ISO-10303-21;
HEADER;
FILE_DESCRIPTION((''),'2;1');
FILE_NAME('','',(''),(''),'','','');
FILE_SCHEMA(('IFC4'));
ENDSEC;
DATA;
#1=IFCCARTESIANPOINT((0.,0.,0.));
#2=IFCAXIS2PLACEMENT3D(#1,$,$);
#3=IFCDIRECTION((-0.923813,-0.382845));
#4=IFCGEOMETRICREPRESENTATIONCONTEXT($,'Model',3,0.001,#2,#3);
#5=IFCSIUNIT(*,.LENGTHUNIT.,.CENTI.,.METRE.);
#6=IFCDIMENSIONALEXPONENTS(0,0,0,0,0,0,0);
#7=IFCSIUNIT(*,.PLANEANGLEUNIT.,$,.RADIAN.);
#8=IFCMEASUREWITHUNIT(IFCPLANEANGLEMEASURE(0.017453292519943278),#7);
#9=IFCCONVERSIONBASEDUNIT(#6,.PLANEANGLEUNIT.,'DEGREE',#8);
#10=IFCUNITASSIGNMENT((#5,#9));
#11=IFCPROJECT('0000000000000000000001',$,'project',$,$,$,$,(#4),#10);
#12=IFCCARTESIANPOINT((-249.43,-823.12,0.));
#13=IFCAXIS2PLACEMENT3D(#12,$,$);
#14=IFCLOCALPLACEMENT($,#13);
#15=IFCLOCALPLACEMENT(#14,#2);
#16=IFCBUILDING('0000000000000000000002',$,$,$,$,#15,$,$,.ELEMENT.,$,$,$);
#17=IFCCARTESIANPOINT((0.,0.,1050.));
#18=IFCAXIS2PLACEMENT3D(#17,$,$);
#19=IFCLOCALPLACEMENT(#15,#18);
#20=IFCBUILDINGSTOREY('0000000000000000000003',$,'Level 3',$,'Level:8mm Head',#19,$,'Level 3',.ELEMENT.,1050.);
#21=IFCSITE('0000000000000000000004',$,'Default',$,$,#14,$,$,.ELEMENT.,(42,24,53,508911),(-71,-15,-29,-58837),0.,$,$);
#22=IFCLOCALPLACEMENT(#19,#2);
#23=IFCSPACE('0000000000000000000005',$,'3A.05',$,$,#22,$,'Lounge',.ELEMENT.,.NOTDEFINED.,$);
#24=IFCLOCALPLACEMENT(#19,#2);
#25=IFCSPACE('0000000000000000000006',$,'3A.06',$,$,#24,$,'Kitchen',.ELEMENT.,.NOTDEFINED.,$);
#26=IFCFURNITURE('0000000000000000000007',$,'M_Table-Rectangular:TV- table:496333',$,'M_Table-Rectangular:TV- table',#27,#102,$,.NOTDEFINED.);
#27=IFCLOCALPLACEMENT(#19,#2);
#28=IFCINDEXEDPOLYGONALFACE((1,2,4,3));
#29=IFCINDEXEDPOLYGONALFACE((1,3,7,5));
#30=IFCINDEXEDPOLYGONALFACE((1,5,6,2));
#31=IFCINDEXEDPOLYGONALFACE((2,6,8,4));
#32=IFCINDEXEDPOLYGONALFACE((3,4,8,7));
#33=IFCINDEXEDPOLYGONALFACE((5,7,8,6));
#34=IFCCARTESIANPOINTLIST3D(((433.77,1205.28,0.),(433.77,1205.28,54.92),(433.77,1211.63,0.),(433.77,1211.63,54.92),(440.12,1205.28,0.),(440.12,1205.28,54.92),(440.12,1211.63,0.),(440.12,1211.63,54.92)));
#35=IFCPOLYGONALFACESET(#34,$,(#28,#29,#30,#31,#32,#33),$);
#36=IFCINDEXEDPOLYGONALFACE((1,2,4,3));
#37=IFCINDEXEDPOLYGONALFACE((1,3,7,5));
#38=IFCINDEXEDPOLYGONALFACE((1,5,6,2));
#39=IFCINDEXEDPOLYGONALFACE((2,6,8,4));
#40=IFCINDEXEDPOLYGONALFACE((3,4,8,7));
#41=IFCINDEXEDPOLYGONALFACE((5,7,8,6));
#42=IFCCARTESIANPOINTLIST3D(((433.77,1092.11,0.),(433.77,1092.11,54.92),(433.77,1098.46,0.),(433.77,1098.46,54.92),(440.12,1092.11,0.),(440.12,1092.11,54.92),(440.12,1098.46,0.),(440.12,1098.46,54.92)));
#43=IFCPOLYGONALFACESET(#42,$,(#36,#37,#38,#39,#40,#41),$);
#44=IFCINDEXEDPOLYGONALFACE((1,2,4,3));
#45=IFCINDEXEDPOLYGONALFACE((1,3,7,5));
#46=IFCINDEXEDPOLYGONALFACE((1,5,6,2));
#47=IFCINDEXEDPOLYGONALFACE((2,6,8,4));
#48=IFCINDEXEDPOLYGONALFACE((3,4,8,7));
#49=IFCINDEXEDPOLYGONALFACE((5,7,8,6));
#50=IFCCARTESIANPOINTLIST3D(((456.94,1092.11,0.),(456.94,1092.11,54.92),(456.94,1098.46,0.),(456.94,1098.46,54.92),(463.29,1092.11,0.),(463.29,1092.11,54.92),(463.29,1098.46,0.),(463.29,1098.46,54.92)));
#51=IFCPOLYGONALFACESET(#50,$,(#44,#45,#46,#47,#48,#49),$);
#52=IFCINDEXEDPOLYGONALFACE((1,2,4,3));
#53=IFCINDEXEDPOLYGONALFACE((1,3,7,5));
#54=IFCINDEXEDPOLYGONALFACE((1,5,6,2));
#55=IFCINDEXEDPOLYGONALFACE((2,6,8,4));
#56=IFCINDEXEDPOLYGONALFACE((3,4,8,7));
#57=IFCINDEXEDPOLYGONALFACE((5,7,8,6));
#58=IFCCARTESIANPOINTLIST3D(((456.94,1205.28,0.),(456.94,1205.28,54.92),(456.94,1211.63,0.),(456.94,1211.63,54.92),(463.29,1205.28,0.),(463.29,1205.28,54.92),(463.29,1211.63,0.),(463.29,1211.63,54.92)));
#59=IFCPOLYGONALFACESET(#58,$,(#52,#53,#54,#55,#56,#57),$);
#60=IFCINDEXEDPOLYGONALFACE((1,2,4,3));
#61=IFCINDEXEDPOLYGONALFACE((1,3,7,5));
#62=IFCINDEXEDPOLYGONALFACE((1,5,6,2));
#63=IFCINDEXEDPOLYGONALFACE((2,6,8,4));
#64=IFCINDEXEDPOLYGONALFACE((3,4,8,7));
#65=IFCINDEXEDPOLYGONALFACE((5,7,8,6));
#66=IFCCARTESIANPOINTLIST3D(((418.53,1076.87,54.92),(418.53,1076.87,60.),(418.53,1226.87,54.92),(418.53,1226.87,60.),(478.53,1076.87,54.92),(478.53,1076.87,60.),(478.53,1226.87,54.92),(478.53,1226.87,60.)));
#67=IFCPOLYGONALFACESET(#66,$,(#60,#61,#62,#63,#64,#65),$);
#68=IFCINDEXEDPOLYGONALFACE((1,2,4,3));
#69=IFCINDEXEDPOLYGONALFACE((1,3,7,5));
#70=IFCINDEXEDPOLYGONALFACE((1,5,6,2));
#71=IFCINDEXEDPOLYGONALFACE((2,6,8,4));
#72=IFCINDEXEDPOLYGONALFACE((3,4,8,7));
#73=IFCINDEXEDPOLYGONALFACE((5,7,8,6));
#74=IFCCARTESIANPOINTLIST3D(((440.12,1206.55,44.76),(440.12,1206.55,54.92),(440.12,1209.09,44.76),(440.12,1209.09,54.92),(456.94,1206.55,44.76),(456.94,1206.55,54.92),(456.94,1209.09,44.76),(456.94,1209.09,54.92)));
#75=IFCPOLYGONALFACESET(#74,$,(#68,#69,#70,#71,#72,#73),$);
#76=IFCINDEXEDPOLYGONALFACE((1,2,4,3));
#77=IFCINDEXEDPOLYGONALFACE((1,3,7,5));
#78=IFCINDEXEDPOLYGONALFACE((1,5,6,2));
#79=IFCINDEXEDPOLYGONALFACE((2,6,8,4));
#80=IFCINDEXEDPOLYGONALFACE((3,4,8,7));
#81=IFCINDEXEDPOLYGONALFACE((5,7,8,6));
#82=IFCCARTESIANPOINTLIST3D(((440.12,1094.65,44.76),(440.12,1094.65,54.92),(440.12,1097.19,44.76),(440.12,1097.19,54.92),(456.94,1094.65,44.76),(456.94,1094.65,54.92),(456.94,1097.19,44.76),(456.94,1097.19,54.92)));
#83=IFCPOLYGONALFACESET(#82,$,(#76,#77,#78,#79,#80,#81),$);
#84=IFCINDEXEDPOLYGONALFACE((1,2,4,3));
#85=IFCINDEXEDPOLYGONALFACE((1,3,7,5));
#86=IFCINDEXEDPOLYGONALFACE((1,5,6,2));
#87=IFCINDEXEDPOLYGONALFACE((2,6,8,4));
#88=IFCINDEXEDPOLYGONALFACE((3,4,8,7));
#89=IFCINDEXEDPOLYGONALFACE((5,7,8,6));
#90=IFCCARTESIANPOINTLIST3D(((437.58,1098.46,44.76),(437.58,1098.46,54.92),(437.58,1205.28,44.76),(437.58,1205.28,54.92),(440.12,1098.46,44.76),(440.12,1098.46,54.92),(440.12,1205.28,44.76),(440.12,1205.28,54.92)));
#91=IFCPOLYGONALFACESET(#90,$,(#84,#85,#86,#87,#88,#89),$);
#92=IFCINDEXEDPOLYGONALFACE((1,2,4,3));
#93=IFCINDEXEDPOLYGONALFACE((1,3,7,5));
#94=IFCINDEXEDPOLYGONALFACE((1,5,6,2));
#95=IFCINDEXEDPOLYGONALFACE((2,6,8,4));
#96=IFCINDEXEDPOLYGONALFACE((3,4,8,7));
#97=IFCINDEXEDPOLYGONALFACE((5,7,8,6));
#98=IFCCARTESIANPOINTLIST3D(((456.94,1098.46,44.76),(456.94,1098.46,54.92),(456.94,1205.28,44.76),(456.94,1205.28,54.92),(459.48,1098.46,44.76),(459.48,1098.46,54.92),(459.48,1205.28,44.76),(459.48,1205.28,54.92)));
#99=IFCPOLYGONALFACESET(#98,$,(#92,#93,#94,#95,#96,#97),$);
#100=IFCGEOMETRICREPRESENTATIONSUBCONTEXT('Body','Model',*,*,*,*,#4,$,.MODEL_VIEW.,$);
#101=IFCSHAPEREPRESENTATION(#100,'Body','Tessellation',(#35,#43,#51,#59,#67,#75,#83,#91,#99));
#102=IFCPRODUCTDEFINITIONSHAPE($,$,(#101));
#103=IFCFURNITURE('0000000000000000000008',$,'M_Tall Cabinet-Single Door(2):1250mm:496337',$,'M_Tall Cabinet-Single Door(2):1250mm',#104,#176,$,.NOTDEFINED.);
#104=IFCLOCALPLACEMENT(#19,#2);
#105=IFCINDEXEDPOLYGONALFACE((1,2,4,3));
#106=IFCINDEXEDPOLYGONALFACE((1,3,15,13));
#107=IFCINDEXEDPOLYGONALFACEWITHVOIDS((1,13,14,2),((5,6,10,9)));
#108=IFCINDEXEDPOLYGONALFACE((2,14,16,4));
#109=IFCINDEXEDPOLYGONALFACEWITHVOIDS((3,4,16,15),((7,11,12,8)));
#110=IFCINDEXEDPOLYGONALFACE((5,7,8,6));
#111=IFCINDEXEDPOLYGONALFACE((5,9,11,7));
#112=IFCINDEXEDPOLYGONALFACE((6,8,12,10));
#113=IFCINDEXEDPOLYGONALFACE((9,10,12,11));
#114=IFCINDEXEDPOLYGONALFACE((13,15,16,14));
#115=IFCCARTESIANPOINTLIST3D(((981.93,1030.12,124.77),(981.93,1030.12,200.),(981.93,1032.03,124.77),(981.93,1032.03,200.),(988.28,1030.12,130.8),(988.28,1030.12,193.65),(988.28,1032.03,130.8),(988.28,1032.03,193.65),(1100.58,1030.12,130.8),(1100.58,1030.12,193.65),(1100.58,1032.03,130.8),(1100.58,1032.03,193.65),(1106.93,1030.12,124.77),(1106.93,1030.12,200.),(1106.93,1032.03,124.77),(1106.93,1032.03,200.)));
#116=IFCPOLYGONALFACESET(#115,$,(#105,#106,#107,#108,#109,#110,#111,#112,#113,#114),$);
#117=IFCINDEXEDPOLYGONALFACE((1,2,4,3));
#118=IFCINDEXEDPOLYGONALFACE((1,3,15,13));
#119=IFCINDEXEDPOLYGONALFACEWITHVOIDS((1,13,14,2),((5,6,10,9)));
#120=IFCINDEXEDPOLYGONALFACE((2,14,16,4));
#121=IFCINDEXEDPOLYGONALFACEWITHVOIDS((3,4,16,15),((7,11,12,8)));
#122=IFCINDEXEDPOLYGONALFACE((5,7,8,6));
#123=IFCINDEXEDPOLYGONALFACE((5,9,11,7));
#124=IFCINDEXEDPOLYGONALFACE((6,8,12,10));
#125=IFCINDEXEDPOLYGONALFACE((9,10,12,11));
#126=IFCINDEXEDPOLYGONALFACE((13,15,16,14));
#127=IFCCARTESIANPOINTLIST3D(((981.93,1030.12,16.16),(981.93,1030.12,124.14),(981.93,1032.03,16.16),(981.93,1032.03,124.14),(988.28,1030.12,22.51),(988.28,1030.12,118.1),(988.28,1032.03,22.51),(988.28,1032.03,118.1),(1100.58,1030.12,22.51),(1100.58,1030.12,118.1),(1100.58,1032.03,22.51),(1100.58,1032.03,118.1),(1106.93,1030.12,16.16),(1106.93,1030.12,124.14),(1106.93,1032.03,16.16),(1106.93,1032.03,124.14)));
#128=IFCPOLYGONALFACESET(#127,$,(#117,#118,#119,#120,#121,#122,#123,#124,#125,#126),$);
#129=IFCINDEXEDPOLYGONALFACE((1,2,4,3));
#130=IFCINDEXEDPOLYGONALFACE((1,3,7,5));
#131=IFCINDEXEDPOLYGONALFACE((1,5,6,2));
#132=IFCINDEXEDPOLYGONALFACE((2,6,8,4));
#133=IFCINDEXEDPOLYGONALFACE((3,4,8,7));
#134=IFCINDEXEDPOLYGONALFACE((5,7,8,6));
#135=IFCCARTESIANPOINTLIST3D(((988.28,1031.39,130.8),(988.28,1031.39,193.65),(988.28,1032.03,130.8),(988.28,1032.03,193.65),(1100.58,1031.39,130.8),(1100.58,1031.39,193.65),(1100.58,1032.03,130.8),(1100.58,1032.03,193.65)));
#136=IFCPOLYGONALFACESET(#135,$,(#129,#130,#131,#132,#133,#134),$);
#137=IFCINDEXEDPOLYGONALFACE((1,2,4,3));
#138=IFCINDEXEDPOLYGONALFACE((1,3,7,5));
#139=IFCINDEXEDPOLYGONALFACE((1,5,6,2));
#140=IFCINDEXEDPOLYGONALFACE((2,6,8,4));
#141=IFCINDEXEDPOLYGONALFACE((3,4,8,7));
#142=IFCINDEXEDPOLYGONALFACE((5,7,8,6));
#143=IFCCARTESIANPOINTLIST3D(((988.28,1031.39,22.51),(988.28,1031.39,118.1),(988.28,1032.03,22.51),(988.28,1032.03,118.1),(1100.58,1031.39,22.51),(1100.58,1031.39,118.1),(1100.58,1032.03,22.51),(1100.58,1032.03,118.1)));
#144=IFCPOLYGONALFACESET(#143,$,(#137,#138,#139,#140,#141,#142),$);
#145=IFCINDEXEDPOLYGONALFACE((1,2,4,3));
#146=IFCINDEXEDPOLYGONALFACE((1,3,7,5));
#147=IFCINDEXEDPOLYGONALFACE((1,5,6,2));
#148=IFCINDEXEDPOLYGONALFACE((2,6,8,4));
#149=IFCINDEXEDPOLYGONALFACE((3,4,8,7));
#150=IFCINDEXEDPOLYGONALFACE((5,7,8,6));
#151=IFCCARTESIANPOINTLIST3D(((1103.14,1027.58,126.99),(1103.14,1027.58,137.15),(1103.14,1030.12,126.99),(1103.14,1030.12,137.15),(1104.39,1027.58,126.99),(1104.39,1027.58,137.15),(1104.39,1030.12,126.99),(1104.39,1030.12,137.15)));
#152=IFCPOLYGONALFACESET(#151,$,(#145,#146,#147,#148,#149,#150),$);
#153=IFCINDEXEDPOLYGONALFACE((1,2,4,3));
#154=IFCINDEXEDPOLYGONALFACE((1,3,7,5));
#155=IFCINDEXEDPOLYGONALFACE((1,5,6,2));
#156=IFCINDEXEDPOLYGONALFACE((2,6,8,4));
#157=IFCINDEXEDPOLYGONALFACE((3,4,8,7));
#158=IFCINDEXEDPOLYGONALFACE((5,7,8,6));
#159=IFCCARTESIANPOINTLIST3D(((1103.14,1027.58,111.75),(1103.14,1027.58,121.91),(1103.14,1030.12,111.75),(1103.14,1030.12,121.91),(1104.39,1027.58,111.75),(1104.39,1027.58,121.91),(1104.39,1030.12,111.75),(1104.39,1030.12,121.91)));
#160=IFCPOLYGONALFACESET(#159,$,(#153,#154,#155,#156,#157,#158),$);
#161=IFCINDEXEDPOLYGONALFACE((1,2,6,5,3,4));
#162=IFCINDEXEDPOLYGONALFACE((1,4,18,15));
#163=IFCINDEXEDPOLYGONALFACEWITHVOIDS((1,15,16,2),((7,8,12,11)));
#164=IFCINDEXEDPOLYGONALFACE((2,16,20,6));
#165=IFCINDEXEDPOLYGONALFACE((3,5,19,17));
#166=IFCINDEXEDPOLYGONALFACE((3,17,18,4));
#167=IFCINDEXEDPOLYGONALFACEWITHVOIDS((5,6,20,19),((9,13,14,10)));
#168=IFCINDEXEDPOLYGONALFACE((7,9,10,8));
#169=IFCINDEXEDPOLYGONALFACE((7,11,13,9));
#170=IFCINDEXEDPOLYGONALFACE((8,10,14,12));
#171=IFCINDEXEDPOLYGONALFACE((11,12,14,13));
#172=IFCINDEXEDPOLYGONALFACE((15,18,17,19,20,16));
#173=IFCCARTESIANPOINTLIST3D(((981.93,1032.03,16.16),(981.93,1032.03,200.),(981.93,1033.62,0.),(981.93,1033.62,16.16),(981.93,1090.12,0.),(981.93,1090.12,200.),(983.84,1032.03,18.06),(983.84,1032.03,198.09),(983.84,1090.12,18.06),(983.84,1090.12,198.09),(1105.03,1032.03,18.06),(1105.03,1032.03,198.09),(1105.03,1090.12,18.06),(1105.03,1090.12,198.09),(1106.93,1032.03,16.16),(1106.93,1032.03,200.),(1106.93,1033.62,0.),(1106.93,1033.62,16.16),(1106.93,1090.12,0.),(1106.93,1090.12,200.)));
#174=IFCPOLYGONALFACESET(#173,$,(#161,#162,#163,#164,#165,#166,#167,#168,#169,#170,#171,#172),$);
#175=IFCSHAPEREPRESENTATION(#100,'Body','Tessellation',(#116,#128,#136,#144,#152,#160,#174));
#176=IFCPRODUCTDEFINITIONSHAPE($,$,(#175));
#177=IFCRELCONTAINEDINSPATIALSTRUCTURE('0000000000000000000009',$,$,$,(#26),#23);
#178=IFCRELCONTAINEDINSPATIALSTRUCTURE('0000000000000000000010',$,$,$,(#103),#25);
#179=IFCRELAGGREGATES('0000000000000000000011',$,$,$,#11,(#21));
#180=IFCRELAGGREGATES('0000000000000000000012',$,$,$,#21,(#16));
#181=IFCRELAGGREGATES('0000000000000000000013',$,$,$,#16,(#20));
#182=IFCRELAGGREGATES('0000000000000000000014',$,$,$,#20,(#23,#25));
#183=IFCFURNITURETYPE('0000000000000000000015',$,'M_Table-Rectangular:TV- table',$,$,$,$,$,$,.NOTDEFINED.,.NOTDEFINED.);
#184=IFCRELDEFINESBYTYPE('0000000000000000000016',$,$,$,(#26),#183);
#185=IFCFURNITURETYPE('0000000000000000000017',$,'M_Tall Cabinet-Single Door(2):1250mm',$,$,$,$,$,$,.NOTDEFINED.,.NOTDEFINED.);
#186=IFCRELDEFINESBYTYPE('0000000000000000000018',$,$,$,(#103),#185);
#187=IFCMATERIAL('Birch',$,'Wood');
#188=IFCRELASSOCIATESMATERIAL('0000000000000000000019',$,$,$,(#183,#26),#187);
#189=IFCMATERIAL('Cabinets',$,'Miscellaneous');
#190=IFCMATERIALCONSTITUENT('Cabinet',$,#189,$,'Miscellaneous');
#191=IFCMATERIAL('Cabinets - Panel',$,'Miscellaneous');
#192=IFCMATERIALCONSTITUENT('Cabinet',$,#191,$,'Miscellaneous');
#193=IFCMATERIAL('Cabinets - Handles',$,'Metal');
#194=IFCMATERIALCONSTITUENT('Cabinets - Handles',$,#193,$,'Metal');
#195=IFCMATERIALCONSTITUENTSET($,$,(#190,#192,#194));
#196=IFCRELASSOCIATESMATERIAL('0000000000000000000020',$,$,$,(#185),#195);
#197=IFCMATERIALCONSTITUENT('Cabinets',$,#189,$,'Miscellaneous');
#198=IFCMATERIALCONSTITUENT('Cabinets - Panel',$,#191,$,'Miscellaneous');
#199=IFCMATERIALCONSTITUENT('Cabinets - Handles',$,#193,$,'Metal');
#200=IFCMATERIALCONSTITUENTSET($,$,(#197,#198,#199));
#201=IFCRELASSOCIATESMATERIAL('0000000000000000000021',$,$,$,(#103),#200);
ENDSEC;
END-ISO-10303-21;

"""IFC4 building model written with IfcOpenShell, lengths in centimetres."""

from ifc_helpers import new_model, entity, si_unit, converted_unit, direction, frame, origin, place, context, subcontext, project, spatial, indexed_curve, outline, extrude, source, transform, mapped, material, constituent, constituent_set, type_object, type_shapes, element, save


model = new_model("IFC4")

# Units and contexts
model_context = context("Model", 3, precision=0.001, world=origin(), true_north=direction((-0.923813, -0.382845)))
body_context = subcontext(model_context, "Body", "Model", "MODEL_VIEW")
ifc_project = project(units=[si_unit("LENGTHUNIT", "METRE", prefix="CENTI"), converted_unit("PLANEANGLEUNIT", "DEGREE", entity("IfcPlaneAngleMeasure", 0.017453292519943278), si_unit("PLANEANGLEUNIT", "RADIAN"), dimensions=[0, 0, 0, 0, 0, 0, 0])], contexts=[model_context])

# Site, building, storey
site_placement = place(None, frame((-249.43, -823.12, 0.0)))
site = spatial("IfcSite", under=ifc_project, at=site_placement, Name="Default", CompositionType="ELEMENT", RefLatitude=(42, 24, 53, 508911), RefLongitude=(-71, -15, -29, -58837), RefElevation=0.0)
building_placement = place(site_placement, origin())
building = spatial("IfcBuilding", under=site, at=building_placement, CompositionType="ELEMENT")
storey_placement = place(building_placement, frame((0.0, 0.0, 1050.0)))
storey = spatial("IfcBuildingStorey", under=building, at=storey_placement, Name="Level 3", ObjectType="Level:8mm Head", LongName="Level 3", CompositionType="ELEMENT", Elevation=1050.0)

# Shared definitions
space_1_placement = place(storey_placement, origin())
space_1 = spatial("IfcSpace", under=storey, at=space_1_placement, Name="3A.05", LongName="Lounge", CompositionType="ELEMENT", PredefinedType="NOTDEFINED")

# Furniture
ifc_material_1 = material(Name="Birch", Category="Wood")
furniture_type_1 = type_object("IfcFurnitureType", Name="M_Table-Rectangular:TV- table", AssemblyPlace="NOTDEFINED", PredefinedType="NOTDEFINED", material=ifc_material_1)
shared_shape_1 = source(origin(), body_context, "Body", "SweptSolid", [
    extrude(outline(indexed_curve([(-3.18, -3.18), (3.18, -3.18), (3.18, 3.18), (-3.18, 3.18), (-3.18, -3.18)], self_intersect=False)), frame((56.58, 11.59, 0.0), z_axis=(0.0, 0.0, 1.0), x_axis=(0.0, -1.0, 0.0)), (0.0, 0.0, 1.0), 54.92),
    extrude(outline(indexed_curve([(-3.17, -3.18), (3.17, -3.18), (3.17, 3.18), (-3.17, 3.18), (-3.17, -3.18)], self_intersect=False)), frame((-56.58, 11.59, 0.0), z_axis=(0.0, 0.0, 1.0), x_axis=(-1.0, 0.0, 0.0)), (0.0, 0.0, 1.0), 54.92),
    extrude(outline(indexed_curve([(-3.17, -3.17), (3.17, -3.17), (3.17, 3.17), (-3.17, 3.17), (-3.17, -3.17)], self_intersect=False)), frame((-56.58, -11.59, 0.0), z_axis=(0.0, 0.0, 1.0), x_axis=(0.0, 1.0, 0.0)), (0.0, 0.0, 1.0), 54.92),
    extrude(outline(indexed_curve([(-3.18, -3.17), (3.18, -3.17), (3.18, 3.17), (-3.18, 3.17), (-3.18, -3.17)], self_intersect=False)), frame((56.58, -11.59, 0.0)), (0.0, 0.0, 1.0), 54.92),
    extrude(outline(indexed_curve([(-75.0, -30.0), (75.0, -30.0), (75.0, 30.0), (-75.0, 30.0), (-75.0, -30.0)], self_intersect=False)), frame((0.0, 0.0, 54.92), z_axis=(0.0, 0.0, 1.0), x_axis=(-1.0, 0.0, 0.0)), (0.0, 0.0, 1.0), 5.08),
    extrude(outline(indexed_curve([(-1.27, -8.41), (1.27, -8.41), (1.27, 8.41), (-1.27, 8.41), (-1.27, -8.41)], self_intersect=False)), frame((55.95, 0.0, 44.76)), (0.0, 0.0, 1.0), 10.16),
    extrude(outline(indexed_curve([(-8.41, -1.27), (8.41, -1.27), (8.41, 1.27), (-8.41, 1.27), (-8.41, -1.27)], self_intersect=False)), frame((-55.95, 0.0, 44.76), z_axis=(0.0, 0.0, 1.0), x_axis=(0.0, 1.0, 0.0)), (0.0, 0.0, 1.0), 10.16),
    extrude(outline(indexed_curve([(-53.41, -1.27), (53.41, -1.27), (53.41, 1.27), (-53.41, 1.27), (-53.41, -1.27)], self_intersect=False)), frame((0.0, 9.68, 44.76), z_axis=(0.0, 0.0, 1.0), x_axis=(-1.0, 0.0, 0.0)), (0.0, 0.0, 1.0), 10.16),
    extrude(outline(indexed_curve([(-1.27, -53.41), (1.27, -53.41), (1.27, 53.41), (-1.27, 53.41), (-1.27, -53.41)], self_intersect=False)), frame((0.0, -9.68, 44.76), z_axis=(0.0, 0.0, 1.0), x_axis=(0.0, 1.0, 0.0)), (0.0, 0.0, 1.0), 10.16),
])
type_shapes(furniture_type_1, [shared_shape_1])
furniture_1_placement = place(space_1_placement, frame((448.53, 1151.87, 0.0), z_axis=(0.0, 0.0, 1.0), x_axis=(0.0, 1.0, 0.0)))
element("IfcFurniture", 1, at=furniture_1_placement, inside=space_1, type_object=furniture_type_1, material=ifc_material_1, Name="M_Table-Rectangular:TV- table:496333", ObjectType="M_Table-Rectangular:TV- table", PredefinedType="NOTDEFINED", context=body_context, shape_type="MappedRepresentation", body=[
    mapped(shared_shape_1, transform((0.0, 0.0, 0.0), scale=1.0)),
])

# Shared definitions
space_2_placement = place(storey_placement, origin())
space_2 = spatial("IfcSpace", under=storey, at=space_2_placement, Name="3A.06", LongName="Kitchen", CompositionType="ELEMENT", PredefinedType="NOTDEFINED")

# Furniture, opening
ifc_material_2 = material(Name="Cabinets", Category="Miscellaneous")
ifc_constituent_1 = constituent(ifc_material_2, Name="Cabinets", Category="Miscellaneous")
ifc_material_3 = material(Name="Cabinets - Panel", Category="Miscellaneous")
ifc_constituent_2 = constituent(ifc_material_3, Name="Cabinets - Panel", Category="Miscellaneous")
ifc_material_4 = material(Name="Cabinets - Handles", Category="Metal")
ifc_constituent_3 = constituent(ifc_material_4, Name="Cabinets - Handles", Category="Metal")
ifc_constituent_set_1 = constituent_set(constituents=[ifc_constituent_1, ifc_constituent_2, ifc_constituent_3])
ifc_constituent_4 = constituent(ifc_material_2, Name="Cabinet", Category="Miscellaneous")
ifc_constituent_5 = constituent(ifc_material_3, Name="Cabinet", Category="Miscellaneous")
ifc_constituent_6 = constituent(ifc_material_4, Name="Cabinets - Handles", Category="Metal")
ifc_constituent_set_2 = constituent_set(constituents=[ifc_constituent_4, ifc_constituent_5, ifc_constituent_6])
furniture_type_2 = type_object("IfcFurnitureType", Name="M_Tall Cabinet-Single Door(2):1250mm", AssemblyPlace="NOTDEFINED", PredefinedType="NOTDEFINED", material=ifc_constituent_set_2)
shared_shape_2 = source(origin(), body_context, "Body", "SweptSolid", [
    extrude(outline(indexed_curve([(-0.95, -60.59), (0.95, -60.59), (0.95, 60.59), (-0.95, 60.59), (-0.95, -60.59)], self_intersect=False)), frame((1.87, -0.95, 18.06), z_axis=(0.0, 0.0, 1.0), x_axis=(0.0, 1.0, 0.0)), (0.0, 0.0, 1.0), 180.03),
    extrude(outline(indexed_curve([(-37.61, -62.5), (37.61, -62.5), (37.61, 62.5), (-37.61, 62.5), (-37.61, -62.5)], self_intersect=False), holes=[indexed_curve([(-31.26, -56.15), (-31.26, 56.15), (31.58, 56.15), (31.58, -56.15), (-31.26, -56.15)], self_intersect=False)]), frame((1.87, -60.0, 162.39), z_axis=(0.0, 1.0, 0.0), x_axis=(0.0, 0.0, -1.0)), (0.0, 0.0, 1.0), 1.91),
    extrude(outline(indexed_curve([(-62.5, -53.99), (62.5, -53.99), (62.5, 53.99), (-62.5, 53.99), (-62.5, -53.99)], self_intersect=False), holes=[indexed_curve([(-56.15, 47.96), (56.15, 47.96), (56.15, -47.64), (-56.15, -47.64), (-56.15, 47.96)], self_intersect=False)]), frame((1.87, -60.0, 70.15), z_axis=(0.0, 1.0, 0.0), x_axis=(-1.0, 0.0, 0.0)), (0.0, 0.0, 1.0), 1.91),
    extrude(outline(indexed_curve([(-0.32, -56.15), (0.32, -56.15), (0.32, 56.15), (-0.32, 56.15), (-0.32, -56.15)], self_intersect=False)), frame((1.87, -58.41, 130.8), z_axis=(0.0, 0.0, 1.0), x_axis=(0.0, 1.0, 0.0)), (0.0, 0.0, 1.0), 62.85),
    extrude(outline(indexed_curve([(-0.32, -56.15), (0.32, -56.15), (0.32, 56.15), (-0.32, 56.15), (-0.32, -56.15)], self_intersect=False)), frame((1.87, -58.41, 22.51), z_axis=(0.0, 0.0, 1.0), x_axis=(0.0, 1.0, 0.0)), (0.0, 0.0, 1.0), 95.6),
    extrude(outline(indexed_curve([(-1.27, -0.63), (1.27, -0.63), (1.27, 0.63), (-1.27, 0.63), (-1.27, -0.63)], self_intersect=False)), frame((61.21, -61.27, 126.99), z_axis=(0.0, 0.0, 1.0), x_axis=(0.0, 1.0, 0.0)), (0.0, 0.0, 1.0), 10.16),
    extrude(outline(indexed_curve([(-1.27, -0.63), (1.27, -0.63), (1.27, 0.63), (-1.27, 0.63), (-1.27, -0.63)], self_intersect=False)), frame((61.21, -61.27, 111.75), z_axis=(0.0, 0.0, 1.0), x_axis=(0.0, 1.0, 0.0)), (0.0, 0.0, 1.0), 10.16),
    extrude(outline(indexed_curve([(-19.9, 55.89), (-19.9, -127.95), (38.2, -127.95), (38.2, 72.05), (-18.3, 72.05), (-18.3, 55.89), (-19.9, 55.89)], self_intersect=False)), frame((-60.63, -38.2, 72.05), z_axis=(-1.0, 0.0, 0.0), x_axis=(0.0, 1.0, 0.0)), (0.0, 0.0, -1.0), 125.0),
])
type_shapes(furniture_type_2, [shared_shape_2])
furniture_2_placement = place(space_2_placement, frame((1042.56, 1090.12, 0.0)))
furniture_2 = element("IfcFurniture", 2, at=furniture_2_placement, inside=space_2, type_object=furniture_type_2, material=ifc_constituent_set_1, Name="M_Tall Cabinet-Single Door(2):1250mm:496337", ObjectType="M_Tall Cabinet-Single Door(2):1250mm", PredefinedType="NOTDEFINED", context=body_context, shape_type="MappedRepresentation", body=[
    mapped(shared_shape_2, transform((0.0, 0.0, 0.0), scale=1.0)),
])
opening_1_placement = place(storey_placement, frame((1042.56, 1090.12, 1050.0)))
element("IfcOpeningElement", 3, at=opening_1_placement, cuts=furniture_2, PredefinedType="OPENING", context=body_context, shape_type="SweptSolid", body=[
    extrude(outline(indexed_curve([(-60.59, -90.02), (60.59, -90.02), (60.59, 90.02), (-60.59, 90.02), (-60.59, -90.02)], self_intersect=False)), frame((1.87, 0.0, -941.92), z_axis=(0.0, -1.0, 0.0), x_axis=(-1.0, 0.0, 0.0)), (0.0, 0.0, 1.0), 58.09),
])

save(model, "model.ifc")
